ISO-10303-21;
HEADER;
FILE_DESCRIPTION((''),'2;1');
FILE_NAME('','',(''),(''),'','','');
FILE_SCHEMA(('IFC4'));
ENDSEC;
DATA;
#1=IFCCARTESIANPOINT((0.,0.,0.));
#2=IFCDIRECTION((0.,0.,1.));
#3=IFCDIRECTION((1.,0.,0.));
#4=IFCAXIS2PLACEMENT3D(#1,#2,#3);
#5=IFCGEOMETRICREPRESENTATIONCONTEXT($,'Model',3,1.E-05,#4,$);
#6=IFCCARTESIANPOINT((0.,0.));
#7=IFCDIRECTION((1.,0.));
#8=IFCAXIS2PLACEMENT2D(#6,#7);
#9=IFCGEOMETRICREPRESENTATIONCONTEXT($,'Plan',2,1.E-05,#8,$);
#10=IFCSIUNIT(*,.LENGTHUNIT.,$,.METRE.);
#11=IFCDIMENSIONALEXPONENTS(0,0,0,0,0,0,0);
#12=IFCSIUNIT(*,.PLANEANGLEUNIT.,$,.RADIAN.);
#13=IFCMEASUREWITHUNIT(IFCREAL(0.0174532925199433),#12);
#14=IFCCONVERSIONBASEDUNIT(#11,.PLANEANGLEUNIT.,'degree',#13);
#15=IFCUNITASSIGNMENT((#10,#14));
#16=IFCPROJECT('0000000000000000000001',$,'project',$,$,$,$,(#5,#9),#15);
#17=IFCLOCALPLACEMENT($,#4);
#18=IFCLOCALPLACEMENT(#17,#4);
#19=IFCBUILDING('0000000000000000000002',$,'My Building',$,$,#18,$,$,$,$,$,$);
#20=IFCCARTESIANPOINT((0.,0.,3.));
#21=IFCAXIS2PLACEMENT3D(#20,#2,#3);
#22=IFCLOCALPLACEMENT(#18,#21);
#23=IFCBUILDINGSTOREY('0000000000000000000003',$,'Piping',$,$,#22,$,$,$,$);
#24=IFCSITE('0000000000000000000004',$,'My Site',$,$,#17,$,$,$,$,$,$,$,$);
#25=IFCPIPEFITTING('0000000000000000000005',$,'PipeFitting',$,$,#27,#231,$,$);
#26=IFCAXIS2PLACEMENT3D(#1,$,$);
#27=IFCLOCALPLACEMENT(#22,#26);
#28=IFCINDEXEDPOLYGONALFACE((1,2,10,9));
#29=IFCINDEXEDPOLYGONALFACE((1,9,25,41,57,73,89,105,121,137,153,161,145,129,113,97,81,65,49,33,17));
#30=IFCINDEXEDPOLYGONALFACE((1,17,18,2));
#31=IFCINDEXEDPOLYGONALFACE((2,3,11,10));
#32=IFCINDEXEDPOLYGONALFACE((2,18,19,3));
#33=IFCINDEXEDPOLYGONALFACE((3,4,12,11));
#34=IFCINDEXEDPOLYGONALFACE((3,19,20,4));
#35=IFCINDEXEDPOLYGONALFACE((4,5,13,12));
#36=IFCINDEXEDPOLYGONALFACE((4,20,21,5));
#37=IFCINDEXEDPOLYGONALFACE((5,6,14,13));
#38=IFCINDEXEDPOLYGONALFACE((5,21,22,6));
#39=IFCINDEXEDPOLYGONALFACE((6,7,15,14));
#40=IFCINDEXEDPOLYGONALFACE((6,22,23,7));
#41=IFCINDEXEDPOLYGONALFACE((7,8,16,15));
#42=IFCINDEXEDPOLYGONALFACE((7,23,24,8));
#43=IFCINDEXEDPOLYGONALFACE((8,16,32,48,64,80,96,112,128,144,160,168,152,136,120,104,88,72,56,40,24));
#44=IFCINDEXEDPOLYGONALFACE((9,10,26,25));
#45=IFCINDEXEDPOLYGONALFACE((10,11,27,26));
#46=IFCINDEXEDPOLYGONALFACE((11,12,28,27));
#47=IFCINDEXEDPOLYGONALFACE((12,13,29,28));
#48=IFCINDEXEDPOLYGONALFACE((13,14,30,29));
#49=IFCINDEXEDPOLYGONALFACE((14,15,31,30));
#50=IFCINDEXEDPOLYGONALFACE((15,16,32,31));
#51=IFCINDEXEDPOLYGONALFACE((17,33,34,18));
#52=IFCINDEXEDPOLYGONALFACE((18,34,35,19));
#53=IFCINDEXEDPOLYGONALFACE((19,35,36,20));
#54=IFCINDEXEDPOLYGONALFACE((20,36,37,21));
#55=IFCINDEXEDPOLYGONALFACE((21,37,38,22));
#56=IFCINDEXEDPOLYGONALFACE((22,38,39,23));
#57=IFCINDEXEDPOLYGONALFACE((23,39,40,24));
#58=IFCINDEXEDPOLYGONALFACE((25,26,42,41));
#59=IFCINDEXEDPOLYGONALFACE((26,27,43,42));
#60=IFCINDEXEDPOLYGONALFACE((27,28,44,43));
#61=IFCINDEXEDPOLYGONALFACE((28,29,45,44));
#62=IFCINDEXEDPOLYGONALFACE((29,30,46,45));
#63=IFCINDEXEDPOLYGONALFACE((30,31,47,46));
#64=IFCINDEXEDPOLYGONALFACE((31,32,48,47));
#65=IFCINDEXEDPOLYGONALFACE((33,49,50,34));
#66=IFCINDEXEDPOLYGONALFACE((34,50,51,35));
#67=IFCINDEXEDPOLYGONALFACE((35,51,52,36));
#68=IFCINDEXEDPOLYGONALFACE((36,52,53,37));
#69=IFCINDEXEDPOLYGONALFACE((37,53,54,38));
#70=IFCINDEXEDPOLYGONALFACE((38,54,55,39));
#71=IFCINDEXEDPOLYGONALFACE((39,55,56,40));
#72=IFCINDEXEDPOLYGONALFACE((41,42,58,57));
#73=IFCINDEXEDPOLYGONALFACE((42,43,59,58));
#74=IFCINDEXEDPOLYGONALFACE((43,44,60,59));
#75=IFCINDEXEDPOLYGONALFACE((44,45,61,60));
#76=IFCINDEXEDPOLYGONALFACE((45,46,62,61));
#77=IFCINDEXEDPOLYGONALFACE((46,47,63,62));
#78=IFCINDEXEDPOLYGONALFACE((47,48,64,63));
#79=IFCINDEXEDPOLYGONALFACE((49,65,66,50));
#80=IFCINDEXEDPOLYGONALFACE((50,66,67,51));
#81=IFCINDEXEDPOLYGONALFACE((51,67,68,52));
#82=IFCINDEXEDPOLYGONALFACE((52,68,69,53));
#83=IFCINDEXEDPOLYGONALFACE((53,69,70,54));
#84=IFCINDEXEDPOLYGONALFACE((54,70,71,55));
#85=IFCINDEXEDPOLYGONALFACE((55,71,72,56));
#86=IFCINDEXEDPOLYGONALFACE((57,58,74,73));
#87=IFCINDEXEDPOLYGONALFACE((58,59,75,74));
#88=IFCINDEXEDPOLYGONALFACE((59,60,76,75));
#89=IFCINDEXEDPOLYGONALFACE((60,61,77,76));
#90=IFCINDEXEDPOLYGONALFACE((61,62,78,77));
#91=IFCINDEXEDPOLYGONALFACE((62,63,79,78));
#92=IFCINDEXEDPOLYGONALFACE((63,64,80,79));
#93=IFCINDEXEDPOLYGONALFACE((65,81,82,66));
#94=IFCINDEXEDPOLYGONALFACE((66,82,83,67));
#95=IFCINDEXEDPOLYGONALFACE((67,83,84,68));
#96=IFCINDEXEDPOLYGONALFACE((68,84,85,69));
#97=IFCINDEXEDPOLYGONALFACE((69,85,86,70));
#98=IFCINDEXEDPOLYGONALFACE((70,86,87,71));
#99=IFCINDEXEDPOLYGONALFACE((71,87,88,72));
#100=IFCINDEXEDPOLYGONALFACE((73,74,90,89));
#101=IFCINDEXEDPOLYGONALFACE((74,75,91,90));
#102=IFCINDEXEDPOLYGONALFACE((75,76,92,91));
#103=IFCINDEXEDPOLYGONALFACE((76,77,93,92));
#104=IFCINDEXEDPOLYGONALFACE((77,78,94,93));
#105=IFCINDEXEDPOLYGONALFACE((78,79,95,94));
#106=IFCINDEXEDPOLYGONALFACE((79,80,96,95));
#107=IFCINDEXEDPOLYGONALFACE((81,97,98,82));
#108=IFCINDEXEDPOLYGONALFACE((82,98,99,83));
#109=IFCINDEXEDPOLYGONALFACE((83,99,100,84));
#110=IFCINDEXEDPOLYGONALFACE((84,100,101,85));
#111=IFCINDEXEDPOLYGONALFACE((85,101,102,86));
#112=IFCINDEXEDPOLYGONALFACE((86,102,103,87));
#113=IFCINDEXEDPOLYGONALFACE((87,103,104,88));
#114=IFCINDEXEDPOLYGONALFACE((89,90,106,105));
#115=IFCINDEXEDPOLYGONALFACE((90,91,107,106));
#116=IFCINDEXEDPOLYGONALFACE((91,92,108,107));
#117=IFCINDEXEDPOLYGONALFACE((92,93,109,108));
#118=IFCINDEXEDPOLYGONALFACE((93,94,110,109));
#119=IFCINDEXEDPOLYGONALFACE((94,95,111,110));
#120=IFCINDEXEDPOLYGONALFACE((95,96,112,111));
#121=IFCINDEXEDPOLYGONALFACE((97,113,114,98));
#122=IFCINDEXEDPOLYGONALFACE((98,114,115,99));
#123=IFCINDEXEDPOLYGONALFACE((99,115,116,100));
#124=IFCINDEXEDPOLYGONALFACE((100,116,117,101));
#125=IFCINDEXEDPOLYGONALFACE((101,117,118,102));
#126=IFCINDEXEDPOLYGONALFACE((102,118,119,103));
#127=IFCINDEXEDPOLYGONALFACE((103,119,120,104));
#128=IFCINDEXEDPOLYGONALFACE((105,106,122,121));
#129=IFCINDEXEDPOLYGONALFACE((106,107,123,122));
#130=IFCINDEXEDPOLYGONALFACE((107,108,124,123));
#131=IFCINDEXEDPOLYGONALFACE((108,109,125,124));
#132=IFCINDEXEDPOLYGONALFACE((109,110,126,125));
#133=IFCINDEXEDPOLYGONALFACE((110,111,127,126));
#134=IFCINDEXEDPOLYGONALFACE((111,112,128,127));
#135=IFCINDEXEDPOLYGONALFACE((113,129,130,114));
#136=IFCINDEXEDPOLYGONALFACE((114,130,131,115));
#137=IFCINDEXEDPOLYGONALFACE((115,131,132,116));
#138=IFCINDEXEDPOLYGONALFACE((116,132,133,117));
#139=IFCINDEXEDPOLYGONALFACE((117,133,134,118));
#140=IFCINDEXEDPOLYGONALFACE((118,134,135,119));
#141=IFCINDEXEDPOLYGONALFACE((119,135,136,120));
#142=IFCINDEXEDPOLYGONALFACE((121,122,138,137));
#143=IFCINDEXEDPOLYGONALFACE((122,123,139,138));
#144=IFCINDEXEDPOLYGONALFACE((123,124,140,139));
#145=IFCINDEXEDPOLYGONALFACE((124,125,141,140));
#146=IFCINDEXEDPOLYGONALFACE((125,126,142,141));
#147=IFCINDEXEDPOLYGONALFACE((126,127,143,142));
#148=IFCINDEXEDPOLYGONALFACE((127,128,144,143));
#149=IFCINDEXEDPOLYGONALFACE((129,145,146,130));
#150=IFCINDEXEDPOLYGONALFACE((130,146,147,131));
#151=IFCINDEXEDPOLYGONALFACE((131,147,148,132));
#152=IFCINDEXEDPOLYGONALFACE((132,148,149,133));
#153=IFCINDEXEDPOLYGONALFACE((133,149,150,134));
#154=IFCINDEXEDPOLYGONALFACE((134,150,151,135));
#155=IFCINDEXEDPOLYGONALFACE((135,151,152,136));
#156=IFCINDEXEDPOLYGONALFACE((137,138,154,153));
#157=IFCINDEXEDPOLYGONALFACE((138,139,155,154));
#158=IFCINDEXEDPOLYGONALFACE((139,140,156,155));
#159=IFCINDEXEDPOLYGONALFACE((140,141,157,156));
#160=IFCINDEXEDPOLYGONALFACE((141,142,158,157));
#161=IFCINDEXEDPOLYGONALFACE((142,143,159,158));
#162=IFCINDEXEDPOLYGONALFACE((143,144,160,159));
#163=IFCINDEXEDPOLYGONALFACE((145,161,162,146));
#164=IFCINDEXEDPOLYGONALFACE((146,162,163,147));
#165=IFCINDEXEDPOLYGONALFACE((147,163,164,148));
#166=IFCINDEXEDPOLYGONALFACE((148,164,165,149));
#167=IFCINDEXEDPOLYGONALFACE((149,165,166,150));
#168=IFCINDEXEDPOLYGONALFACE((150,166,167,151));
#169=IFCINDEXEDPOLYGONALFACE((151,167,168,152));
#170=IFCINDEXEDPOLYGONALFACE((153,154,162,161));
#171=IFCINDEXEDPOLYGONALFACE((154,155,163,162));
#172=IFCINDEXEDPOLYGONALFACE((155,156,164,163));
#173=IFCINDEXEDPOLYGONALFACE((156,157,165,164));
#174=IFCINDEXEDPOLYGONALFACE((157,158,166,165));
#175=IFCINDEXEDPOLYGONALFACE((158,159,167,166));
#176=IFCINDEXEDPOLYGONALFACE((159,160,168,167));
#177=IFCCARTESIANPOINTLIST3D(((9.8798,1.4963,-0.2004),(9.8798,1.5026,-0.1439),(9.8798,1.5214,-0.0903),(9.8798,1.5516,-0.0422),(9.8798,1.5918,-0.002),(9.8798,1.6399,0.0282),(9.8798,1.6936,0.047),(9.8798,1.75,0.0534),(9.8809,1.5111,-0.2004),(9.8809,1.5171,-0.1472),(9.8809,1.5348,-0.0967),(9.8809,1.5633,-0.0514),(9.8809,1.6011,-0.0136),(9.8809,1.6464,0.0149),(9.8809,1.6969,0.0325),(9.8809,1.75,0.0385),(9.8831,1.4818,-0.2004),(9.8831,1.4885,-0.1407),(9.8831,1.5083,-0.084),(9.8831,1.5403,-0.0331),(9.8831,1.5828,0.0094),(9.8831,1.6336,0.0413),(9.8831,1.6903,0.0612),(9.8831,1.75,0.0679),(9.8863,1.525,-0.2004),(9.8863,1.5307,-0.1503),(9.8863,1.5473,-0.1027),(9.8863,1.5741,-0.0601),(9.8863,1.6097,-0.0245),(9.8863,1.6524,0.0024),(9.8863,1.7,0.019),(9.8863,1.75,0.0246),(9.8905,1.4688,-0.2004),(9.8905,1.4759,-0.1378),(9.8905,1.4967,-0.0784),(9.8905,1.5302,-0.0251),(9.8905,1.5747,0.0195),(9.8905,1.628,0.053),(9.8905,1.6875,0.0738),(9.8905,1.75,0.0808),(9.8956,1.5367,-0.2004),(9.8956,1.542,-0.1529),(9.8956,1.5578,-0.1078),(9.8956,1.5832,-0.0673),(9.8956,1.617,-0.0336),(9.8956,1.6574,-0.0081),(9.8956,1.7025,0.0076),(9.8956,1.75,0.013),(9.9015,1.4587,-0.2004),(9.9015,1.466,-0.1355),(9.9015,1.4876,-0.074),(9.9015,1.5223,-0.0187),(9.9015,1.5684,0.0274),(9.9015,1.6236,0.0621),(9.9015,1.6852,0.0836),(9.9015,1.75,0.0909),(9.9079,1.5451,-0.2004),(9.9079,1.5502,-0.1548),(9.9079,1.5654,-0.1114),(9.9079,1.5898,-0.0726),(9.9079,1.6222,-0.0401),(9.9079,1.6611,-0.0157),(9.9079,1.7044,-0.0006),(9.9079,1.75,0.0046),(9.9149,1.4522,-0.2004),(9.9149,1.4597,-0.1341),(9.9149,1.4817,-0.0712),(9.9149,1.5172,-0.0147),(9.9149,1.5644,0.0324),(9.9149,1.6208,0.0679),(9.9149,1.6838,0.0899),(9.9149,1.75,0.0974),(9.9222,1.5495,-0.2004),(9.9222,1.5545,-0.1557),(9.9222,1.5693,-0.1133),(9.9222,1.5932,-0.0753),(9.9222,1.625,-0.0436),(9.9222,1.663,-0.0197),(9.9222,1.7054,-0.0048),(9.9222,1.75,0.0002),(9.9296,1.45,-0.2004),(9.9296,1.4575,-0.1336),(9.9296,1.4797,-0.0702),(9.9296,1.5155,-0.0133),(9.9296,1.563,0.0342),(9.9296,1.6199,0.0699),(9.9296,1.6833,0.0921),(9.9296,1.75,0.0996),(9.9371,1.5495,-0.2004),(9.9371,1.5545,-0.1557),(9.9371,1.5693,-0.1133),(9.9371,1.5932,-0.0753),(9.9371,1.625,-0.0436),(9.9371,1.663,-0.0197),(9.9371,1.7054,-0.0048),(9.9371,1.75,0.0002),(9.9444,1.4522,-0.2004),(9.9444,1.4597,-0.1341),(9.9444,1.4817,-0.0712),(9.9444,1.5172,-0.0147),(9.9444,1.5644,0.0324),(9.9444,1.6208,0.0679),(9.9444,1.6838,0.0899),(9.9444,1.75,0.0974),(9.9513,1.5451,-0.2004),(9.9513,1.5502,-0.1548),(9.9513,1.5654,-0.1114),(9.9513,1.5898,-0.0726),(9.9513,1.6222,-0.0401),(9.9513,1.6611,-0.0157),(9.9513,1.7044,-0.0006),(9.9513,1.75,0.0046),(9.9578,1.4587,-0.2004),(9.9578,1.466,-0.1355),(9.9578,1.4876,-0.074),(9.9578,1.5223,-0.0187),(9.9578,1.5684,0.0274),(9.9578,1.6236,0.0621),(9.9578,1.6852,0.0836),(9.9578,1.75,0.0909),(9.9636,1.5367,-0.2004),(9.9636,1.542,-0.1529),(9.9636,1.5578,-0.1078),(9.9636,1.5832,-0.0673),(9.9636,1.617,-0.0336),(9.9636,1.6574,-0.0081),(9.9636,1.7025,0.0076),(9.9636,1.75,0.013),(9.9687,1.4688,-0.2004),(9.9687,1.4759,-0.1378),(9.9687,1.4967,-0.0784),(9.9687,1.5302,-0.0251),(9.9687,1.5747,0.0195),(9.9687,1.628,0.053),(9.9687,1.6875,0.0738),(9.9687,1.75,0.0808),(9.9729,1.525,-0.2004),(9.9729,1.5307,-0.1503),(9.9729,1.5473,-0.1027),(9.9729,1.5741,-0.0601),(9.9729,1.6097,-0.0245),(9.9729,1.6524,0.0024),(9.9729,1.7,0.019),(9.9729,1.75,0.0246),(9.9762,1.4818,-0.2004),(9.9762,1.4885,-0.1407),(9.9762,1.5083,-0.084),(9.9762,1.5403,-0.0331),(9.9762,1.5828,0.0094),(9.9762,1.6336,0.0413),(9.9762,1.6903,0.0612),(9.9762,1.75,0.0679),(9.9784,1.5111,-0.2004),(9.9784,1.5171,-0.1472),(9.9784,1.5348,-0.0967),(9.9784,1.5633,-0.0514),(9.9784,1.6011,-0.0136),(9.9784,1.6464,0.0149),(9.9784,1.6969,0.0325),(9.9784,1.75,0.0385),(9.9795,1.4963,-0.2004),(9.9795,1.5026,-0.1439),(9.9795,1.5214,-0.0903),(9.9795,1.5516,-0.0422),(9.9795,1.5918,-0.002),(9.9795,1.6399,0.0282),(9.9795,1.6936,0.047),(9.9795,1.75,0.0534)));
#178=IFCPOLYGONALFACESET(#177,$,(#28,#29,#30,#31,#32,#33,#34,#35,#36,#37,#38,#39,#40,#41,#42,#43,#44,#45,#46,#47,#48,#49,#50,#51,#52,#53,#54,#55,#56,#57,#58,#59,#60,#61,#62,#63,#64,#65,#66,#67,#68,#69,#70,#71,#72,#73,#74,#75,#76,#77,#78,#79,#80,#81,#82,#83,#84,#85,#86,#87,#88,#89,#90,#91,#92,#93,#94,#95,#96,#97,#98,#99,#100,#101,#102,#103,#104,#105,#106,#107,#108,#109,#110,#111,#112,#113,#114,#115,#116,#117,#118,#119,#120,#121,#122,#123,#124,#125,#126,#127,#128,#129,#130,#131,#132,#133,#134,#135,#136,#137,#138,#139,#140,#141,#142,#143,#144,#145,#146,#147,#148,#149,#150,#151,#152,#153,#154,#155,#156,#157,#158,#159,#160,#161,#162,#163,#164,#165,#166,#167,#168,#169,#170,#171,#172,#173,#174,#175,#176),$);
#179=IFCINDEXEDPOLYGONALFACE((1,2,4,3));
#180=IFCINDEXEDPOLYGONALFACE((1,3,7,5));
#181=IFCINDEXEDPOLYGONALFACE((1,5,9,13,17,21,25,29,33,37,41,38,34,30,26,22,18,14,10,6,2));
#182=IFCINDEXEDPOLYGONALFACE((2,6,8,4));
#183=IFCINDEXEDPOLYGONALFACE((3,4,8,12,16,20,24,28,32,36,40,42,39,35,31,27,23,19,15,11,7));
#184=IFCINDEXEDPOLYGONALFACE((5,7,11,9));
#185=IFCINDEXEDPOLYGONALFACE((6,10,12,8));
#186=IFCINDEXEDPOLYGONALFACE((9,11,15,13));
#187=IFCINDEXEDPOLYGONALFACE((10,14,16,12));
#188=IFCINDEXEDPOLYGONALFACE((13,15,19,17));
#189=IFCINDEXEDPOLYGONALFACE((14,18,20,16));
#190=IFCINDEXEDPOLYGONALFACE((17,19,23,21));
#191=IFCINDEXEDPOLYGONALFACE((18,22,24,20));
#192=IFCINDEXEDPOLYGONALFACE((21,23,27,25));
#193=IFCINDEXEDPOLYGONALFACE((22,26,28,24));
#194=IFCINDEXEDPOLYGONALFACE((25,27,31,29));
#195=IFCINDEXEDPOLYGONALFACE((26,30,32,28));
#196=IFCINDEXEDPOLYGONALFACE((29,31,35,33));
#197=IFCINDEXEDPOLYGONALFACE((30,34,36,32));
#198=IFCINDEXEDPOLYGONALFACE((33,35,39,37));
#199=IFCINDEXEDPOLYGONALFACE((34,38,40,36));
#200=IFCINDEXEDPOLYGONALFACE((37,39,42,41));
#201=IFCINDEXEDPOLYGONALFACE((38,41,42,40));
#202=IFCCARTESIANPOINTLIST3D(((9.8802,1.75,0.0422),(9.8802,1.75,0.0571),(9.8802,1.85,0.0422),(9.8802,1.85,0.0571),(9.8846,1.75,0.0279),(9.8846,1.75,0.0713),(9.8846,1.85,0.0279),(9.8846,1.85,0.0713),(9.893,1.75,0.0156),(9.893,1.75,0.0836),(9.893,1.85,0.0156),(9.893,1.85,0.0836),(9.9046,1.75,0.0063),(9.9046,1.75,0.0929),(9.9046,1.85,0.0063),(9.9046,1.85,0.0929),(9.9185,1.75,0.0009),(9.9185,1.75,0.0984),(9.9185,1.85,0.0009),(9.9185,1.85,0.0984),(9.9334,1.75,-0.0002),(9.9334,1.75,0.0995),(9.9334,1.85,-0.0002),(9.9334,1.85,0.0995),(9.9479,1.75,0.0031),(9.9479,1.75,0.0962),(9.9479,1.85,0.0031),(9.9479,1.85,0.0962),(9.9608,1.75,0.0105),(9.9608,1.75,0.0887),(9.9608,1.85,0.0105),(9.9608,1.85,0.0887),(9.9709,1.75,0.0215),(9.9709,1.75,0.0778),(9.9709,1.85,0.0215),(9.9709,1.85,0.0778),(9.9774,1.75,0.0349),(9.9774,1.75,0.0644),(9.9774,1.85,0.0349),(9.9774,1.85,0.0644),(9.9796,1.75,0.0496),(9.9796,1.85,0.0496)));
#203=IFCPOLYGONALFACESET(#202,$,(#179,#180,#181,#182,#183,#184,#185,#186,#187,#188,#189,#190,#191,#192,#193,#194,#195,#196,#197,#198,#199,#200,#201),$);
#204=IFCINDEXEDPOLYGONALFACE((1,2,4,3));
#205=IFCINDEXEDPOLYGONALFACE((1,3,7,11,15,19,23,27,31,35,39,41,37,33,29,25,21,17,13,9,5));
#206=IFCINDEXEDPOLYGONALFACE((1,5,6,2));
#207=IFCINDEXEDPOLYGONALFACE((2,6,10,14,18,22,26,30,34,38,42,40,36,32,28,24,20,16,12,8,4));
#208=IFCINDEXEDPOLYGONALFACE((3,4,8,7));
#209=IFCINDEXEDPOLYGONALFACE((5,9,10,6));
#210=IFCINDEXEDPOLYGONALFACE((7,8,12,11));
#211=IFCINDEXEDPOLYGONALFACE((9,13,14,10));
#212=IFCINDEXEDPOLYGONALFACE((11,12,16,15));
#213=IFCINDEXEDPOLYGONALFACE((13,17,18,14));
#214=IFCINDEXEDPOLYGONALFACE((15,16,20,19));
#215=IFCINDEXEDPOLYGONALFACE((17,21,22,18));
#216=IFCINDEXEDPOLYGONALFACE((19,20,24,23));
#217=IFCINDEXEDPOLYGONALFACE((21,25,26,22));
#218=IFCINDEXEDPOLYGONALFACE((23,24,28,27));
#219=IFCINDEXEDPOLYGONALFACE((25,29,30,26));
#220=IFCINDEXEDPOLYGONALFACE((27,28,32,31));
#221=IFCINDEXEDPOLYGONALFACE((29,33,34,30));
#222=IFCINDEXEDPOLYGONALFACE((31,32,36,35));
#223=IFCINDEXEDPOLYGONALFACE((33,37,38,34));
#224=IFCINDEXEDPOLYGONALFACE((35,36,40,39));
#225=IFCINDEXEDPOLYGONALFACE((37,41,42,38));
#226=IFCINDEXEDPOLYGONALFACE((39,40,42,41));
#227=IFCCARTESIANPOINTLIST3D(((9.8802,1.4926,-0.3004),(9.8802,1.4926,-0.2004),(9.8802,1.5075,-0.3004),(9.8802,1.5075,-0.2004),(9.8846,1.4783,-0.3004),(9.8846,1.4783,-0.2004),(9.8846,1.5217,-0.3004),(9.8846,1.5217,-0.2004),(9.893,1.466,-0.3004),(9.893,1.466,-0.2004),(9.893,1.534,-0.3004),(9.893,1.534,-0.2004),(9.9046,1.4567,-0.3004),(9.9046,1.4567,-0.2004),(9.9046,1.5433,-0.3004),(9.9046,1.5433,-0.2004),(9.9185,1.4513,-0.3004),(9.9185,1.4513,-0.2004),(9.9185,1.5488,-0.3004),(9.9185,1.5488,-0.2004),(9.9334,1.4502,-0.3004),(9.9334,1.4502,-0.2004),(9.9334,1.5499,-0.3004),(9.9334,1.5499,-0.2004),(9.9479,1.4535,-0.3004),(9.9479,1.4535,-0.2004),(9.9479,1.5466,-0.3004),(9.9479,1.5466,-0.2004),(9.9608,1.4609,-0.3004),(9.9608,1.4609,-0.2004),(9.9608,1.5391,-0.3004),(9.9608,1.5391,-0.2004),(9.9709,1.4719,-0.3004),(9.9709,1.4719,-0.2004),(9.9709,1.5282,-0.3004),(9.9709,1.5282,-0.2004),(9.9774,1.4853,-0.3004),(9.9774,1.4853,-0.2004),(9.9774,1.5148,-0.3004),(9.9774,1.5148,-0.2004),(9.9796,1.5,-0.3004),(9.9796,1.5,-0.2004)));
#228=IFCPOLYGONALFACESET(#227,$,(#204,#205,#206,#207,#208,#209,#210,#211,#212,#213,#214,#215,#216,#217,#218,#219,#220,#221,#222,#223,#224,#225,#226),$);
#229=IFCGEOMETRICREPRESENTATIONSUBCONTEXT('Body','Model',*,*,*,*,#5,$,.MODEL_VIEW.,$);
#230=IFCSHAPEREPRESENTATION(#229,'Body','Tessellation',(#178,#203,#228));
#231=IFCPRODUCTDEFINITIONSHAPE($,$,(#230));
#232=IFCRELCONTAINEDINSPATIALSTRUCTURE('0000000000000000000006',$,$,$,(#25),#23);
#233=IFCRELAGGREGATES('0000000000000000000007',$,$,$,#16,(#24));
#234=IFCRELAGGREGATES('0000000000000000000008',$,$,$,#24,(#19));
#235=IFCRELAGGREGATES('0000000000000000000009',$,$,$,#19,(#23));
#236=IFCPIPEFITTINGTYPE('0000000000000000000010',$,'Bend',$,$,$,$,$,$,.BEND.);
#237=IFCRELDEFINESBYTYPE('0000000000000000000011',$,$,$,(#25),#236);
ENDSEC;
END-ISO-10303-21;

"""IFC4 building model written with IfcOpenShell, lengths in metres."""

from ifc_helpers import new_model, entity, si_unit, converted_unit, frame, origin_with_axes, origin_2d_with_axis, place, context, subcontext, project, spatial, circle, extrude, source, transform, mapped, type_object, type_shapes, element, save


model = new_model("IFC4")

# Units and contexts
model_context = context("Model", 3, precision=1e-05, world=origin_with_axes())
plan_context = context("Plan", 2, precision=1e-05, world=origin_2d_with_axis())
body_context = subcontext(model_context, "Body", "Model", "MODEL_VIEW")
ifc_project = project(units=[si_unit("LENGTHUNIT", "METRE"), converted_unit("PLANEANGLEUNIT", "degree", entity("IfcReal", 0.0174532925199433), si_unit("PLANEANGLEUNIT", "RADIAN"), dimensions=[0, 0, 0, 0, 0, 0, 0])], contexts=[model_context, plan_context])

# Site, building, storey
site_placement = place(None, origin_with_axes())
site = spatial("IfcSite", under=ifc_project, at=site_placement, Name="My Site")
building_placement = place(site_placement, origin_with_axes())
building = spatial("IfcBuilding", under=site, at=building_placement, Name="My Building")
storey_placement = place(building_placement, frame((0.0, 0.0, 3.0), z_axis=(0.0, 0.0, 1.0), x_axis=(1.0, 0.0, 0.0)))
storey = spatial("IfcBuildingStorey", under=building, at=storey_placement, Name="Piping")

# Pipe fitting
pipe_fitting_type_1 = type_object("IfcPipeFittingType", Name="Bend", PredefinedType="BEND")
shared_shape = source(origin_with_axes(), body_context, "Body", "SolidModel", [
    entity("IfcSweptDiskSolid", entity("IfcIndexedPolyCurve", entity("IfcCartesianPointList3D", [[0.0, 0.0, 0.1], [0.0, -0.0732, 0.2768], [0.0, -0.25, 0.35]]), [entity("IfcArcIndex", [1, 2, 3])]), 0.05),
    extrude(circle(Radius=0.05), origin_with_axes(), (0.0, 0.0, 1.0), 0.1),
    extrude(circle(Radius=0.05), frame((0.0, -0.25, 0.35), z_axis=(0.0, -1.0, 0.0), x_axis=(1.0, 0.0, 0.0)), (0.0, 0.0, 1.0), 0.1),
])
type_shapes(pipe_fitting_type_1, [shared_shape])
for number, where, z_axis, x_axis, name in (
    (1, (9.9296, 1.85, 0.0496), (0.0, -1.0, 0.0), (1.0, 0.0, 0.0), "PipeFitting"),
):
    element("IfcPipeFitting", number, at=place(storey_placement, frame(where, z_axis=z_axis, x_axis=x_axis)), inside=storey, type_object=pipe_fitting_type_1, Name=name, context=body_context, shape_type="MappedRepresentation", body=[
        mapped(shared_shape, transform((0.0, 0.0, 0.0), x_axis=(1.0, 0.0, 0.0), y_axis=(0.0, 1.0, 0.0), z_axis=(0.0, 0.0, 1.0), scale=1.0)),
    ])

save(model, "model.ifc")
